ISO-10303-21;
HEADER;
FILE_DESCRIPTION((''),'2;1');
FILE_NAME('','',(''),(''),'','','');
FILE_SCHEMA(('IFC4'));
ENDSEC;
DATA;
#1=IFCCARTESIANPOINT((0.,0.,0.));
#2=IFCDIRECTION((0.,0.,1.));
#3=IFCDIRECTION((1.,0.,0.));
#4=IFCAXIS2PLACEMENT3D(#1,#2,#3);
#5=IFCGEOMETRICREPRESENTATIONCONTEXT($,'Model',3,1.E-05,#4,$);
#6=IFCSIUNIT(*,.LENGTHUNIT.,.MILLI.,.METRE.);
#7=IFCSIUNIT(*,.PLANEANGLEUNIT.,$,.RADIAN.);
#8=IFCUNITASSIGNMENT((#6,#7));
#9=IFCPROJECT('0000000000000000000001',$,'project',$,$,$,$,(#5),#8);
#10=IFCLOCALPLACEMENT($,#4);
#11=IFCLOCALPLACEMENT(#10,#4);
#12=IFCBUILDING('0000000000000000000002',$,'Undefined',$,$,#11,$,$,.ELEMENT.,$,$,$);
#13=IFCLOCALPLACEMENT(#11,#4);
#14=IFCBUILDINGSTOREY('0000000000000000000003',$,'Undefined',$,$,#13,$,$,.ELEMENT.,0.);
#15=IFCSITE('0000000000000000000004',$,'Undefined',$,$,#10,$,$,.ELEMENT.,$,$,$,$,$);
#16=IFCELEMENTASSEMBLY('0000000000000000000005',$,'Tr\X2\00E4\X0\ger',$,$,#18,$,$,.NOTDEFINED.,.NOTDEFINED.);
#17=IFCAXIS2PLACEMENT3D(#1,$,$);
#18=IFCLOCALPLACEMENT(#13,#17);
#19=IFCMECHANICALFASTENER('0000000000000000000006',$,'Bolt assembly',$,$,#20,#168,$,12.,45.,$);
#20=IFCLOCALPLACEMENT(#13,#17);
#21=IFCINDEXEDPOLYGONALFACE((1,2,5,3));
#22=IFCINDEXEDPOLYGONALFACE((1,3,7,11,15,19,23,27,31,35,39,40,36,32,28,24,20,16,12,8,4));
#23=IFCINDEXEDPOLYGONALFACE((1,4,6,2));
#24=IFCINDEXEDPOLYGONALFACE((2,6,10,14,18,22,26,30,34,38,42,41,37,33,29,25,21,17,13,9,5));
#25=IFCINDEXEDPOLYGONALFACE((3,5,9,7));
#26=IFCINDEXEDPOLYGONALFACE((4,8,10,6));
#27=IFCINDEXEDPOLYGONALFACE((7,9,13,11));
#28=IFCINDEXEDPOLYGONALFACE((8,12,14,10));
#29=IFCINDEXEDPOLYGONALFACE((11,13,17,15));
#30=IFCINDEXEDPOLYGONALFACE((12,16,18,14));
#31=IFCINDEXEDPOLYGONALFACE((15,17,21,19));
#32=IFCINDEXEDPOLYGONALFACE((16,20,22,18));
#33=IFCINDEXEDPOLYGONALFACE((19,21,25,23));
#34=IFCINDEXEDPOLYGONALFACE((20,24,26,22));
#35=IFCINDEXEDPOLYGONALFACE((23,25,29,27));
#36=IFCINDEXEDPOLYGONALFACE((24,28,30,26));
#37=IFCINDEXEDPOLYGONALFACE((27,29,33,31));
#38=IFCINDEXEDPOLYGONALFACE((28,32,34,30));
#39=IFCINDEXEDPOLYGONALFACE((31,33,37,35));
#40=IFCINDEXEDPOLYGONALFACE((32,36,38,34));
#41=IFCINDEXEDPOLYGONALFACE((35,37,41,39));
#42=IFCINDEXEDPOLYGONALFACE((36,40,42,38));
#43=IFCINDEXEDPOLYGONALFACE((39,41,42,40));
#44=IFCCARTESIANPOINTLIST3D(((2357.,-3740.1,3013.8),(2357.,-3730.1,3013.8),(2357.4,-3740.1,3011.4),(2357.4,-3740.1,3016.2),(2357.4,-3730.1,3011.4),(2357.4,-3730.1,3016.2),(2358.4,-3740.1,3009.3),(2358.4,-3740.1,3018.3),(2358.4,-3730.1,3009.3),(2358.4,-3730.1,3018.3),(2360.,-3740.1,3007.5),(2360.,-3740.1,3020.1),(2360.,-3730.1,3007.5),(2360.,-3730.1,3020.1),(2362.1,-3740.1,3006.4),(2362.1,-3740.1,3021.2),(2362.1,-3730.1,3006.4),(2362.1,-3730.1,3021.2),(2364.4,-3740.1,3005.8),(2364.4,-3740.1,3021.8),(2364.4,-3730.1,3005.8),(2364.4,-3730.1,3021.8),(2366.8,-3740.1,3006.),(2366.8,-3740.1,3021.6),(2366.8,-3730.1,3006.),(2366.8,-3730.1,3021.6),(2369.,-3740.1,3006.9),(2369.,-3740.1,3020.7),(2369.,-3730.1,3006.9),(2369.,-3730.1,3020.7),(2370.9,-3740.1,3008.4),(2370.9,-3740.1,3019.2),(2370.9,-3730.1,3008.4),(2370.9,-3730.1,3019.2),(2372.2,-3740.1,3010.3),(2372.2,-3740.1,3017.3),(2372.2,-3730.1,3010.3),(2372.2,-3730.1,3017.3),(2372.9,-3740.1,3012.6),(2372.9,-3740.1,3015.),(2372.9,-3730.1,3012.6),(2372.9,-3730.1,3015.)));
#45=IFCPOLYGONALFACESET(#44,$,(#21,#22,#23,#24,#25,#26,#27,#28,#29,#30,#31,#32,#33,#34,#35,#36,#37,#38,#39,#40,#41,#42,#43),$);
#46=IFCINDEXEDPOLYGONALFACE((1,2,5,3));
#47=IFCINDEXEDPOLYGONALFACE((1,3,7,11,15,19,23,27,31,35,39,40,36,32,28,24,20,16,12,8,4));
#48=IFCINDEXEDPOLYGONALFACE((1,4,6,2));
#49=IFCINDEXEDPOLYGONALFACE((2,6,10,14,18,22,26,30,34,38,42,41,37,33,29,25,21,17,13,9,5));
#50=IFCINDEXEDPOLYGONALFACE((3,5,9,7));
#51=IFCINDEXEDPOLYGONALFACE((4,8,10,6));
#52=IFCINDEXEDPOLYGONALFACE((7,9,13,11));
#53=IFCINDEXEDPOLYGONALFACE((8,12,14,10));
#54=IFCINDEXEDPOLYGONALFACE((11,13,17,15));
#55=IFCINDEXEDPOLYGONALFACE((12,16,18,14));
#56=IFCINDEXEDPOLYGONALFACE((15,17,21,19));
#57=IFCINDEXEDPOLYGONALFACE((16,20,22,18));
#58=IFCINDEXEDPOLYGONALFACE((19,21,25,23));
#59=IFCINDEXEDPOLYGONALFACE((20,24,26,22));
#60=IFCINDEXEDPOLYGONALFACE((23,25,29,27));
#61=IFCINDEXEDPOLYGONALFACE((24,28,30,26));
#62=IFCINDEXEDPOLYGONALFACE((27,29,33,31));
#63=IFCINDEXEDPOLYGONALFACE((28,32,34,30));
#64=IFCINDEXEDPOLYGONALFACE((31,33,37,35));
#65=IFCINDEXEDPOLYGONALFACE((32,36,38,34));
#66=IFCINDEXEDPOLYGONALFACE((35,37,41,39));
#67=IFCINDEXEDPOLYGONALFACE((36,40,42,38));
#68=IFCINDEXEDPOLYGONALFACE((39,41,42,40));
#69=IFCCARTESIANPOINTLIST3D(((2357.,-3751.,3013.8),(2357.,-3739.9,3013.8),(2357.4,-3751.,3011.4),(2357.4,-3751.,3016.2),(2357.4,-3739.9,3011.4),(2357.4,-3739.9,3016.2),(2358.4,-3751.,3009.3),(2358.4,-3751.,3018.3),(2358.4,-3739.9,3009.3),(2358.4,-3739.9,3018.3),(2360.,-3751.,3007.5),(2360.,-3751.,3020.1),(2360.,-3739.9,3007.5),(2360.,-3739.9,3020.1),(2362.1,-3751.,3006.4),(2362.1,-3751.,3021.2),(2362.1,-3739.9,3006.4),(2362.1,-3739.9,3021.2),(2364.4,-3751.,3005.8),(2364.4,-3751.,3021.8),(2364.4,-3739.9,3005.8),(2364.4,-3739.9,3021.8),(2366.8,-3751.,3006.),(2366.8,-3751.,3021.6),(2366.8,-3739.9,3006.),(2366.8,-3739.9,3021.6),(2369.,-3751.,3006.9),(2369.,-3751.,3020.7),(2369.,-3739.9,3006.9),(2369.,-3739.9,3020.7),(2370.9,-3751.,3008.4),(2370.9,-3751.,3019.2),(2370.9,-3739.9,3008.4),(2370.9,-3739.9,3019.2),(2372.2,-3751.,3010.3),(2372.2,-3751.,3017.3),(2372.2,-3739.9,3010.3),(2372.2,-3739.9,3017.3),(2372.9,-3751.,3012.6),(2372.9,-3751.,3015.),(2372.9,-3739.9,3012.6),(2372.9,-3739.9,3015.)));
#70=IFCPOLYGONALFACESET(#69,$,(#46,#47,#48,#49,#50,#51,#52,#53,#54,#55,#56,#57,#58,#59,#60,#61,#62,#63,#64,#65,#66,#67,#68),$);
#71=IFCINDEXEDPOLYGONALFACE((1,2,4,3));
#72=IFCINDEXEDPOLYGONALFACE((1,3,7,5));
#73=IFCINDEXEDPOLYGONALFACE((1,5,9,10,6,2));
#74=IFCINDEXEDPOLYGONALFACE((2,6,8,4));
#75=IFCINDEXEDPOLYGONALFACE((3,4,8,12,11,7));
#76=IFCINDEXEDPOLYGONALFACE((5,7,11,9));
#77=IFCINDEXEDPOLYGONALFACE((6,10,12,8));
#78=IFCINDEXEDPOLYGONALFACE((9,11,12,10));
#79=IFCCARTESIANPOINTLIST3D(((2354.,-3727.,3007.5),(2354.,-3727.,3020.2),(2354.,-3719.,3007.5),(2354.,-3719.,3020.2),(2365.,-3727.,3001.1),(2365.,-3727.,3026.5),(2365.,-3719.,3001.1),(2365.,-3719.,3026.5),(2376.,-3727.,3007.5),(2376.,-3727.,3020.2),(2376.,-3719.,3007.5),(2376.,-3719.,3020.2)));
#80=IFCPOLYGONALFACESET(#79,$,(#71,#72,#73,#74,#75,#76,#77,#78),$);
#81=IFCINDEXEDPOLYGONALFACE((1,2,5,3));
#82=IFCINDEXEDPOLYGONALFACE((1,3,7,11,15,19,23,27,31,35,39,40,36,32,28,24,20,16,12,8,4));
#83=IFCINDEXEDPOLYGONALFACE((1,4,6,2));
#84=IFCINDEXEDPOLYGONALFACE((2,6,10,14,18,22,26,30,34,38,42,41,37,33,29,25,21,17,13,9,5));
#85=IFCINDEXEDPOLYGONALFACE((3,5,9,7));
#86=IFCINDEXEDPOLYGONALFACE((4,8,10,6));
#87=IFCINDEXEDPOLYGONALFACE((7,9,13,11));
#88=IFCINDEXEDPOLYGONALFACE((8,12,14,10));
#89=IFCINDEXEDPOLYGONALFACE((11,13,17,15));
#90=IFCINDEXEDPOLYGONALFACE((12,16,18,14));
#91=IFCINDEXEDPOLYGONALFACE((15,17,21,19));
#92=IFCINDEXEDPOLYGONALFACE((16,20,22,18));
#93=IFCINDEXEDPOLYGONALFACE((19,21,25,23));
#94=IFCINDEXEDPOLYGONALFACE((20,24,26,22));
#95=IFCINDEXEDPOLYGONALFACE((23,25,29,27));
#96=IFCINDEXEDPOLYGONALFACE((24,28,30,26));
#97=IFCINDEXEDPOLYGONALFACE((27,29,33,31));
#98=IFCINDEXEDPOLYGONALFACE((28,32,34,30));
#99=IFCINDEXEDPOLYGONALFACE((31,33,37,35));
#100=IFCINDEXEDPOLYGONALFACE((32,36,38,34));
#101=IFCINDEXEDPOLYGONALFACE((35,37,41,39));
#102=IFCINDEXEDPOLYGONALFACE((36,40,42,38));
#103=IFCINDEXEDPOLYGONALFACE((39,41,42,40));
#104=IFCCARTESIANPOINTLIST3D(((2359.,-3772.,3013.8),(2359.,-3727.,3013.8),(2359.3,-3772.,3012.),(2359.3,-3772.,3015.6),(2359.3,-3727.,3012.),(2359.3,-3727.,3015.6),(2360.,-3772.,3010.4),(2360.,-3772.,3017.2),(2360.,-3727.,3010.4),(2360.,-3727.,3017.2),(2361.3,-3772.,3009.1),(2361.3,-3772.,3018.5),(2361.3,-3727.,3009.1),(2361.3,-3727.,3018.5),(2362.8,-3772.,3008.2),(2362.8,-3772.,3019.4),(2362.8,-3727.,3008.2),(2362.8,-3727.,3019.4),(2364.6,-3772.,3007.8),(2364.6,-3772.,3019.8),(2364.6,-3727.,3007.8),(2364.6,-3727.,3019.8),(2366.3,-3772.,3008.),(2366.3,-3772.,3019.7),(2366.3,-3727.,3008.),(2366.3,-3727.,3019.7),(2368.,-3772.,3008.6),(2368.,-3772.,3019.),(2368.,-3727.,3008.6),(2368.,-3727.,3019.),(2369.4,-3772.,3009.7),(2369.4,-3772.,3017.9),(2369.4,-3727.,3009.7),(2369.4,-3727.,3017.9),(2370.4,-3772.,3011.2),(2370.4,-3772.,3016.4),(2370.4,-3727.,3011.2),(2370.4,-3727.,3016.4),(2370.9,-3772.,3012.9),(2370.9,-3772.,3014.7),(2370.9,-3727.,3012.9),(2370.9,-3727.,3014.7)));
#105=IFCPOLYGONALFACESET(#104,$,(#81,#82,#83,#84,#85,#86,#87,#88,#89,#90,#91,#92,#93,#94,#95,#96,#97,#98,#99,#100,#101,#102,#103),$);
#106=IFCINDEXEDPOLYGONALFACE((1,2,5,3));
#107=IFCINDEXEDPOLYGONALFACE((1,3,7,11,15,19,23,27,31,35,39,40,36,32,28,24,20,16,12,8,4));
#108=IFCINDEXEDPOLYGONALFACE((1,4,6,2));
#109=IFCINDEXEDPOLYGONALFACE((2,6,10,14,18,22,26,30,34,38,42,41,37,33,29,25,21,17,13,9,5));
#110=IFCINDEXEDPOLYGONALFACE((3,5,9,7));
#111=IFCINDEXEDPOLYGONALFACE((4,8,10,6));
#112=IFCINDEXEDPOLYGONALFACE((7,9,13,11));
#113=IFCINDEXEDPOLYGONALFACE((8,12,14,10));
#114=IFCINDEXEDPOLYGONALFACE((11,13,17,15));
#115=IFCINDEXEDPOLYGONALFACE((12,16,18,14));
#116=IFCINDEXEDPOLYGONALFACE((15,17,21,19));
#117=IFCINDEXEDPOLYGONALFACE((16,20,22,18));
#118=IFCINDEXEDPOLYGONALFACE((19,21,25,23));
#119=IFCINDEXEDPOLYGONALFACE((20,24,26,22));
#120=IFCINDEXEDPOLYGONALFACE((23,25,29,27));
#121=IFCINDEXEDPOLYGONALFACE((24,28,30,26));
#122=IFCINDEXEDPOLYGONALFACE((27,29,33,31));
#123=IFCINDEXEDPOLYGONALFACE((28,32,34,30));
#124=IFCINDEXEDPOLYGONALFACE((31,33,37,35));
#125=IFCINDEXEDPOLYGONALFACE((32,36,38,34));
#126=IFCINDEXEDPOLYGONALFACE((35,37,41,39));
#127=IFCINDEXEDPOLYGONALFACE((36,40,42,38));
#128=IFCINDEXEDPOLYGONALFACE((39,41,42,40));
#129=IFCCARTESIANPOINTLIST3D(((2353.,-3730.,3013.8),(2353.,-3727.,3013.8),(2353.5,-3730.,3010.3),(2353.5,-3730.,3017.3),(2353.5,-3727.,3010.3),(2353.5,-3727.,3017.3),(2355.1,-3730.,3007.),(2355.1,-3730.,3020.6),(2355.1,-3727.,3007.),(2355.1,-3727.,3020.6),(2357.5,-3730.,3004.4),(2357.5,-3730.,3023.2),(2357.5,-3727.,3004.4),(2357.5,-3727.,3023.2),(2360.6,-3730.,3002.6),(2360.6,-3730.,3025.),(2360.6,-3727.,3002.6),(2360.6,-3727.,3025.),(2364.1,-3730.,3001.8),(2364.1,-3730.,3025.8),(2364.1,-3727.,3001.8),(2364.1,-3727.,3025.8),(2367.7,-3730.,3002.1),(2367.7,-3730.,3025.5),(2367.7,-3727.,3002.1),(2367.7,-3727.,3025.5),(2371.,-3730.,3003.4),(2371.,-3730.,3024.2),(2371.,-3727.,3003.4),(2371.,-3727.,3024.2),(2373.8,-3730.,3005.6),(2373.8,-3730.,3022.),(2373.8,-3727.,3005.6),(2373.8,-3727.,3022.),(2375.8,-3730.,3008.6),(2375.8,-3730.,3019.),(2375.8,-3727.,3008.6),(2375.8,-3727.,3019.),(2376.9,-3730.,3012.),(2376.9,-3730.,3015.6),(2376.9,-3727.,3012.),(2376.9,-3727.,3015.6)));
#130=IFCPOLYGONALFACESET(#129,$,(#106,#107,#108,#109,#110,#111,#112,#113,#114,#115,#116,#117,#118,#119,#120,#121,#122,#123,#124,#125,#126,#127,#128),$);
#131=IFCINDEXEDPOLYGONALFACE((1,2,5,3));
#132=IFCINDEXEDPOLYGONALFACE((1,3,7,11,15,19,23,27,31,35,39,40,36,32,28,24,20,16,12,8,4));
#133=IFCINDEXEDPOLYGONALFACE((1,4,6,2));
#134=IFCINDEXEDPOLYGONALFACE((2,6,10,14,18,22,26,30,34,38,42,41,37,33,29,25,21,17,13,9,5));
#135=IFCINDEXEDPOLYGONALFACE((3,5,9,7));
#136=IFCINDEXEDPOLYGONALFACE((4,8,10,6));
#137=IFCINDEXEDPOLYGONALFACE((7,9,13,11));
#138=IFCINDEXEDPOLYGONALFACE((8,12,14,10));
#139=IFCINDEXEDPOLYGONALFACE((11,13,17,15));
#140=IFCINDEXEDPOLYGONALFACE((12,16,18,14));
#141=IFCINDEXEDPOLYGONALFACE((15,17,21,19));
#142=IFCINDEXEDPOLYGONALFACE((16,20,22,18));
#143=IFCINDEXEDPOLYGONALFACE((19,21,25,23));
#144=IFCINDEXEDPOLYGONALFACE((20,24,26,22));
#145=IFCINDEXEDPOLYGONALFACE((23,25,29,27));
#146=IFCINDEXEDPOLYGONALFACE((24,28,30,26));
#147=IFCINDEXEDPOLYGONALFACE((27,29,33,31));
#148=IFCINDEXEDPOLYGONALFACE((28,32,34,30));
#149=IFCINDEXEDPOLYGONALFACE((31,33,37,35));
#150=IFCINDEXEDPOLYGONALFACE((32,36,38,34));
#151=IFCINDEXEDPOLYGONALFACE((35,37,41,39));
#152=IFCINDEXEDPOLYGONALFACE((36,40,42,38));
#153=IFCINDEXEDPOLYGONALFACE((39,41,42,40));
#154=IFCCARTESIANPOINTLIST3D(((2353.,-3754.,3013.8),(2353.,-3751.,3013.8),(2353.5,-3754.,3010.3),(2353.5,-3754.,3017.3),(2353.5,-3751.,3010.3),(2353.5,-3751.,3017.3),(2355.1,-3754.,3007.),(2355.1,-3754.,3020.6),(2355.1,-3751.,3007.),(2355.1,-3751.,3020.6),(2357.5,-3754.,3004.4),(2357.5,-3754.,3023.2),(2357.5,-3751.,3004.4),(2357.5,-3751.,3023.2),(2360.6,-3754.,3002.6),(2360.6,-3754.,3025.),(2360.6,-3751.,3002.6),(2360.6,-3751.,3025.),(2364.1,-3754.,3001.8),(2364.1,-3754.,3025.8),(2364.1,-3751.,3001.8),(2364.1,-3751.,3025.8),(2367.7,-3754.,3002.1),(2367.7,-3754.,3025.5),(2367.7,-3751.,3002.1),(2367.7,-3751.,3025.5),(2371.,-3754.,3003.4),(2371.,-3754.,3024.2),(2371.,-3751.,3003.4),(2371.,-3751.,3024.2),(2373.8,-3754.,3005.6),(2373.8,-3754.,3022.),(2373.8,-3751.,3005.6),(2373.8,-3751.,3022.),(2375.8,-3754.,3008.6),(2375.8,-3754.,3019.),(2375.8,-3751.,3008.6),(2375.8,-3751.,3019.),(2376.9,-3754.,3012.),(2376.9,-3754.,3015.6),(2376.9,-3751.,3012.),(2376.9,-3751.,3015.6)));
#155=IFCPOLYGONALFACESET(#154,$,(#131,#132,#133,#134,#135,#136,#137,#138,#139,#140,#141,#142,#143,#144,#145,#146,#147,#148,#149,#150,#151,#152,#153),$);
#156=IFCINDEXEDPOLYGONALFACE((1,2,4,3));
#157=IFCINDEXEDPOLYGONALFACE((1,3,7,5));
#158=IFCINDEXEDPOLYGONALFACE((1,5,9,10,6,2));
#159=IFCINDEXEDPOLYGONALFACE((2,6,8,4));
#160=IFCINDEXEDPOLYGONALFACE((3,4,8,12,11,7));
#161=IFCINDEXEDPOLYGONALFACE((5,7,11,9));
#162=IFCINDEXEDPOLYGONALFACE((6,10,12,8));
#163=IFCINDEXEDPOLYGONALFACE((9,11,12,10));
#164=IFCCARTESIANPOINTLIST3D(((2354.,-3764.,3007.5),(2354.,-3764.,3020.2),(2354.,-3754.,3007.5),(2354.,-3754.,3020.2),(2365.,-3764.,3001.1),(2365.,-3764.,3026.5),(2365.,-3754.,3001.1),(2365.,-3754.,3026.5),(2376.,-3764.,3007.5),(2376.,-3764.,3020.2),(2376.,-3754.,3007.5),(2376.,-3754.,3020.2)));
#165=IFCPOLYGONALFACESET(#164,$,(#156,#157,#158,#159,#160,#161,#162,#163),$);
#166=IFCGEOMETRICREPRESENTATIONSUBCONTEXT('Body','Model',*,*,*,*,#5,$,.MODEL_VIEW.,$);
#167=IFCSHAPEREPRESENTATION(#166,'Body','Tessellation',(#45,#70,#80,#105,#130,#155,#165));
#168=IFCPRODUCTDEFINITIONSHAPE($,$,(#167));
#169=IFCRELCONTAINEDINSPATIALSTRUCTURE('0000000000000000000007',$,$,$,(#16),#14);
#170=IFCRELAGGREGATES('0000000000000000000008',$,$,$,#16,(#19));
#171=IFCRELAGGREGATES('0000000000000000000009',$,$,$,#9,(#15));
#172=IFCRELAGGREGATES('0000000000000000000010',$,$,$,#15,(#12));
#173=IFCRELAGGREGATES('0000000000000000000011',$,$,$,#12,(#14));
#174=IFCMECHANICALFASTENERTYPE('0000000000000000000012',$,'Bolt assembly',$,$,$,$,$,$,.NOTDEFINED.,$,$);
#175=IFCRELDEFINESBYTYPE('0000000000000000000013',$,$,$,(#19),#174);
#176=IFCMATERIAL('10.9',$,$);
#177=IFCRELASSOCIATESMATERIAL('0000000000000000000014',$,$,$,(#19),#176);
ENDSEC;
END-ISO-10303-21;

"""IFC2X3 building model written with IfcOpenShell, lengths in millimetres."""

from ifc_helpers import new_model, si_unit, frame, origin_with_axes, origin_2d_with_axis, place, context, subcontext, project, spatial, polyline, circle, outline, extrude, source, transform, mapped, material, type_object, element, aggregate, save


model = new_model("IFC2X3")

# Units and contexts
model_context = context("Model", 3, precision=1e-05, world=origin_with_axes())
body_context = subcontext(model_context, "Body", "Model", "MODEL_VIEW")
ifc_project = project(units=[si_unit("LENGTHUNIT", "METRE", prefix="MILLI"), si_unit("PLANEANGLEUNIT", "RADIAN")], contexts=[model_context])

# Site, building, storey
site_placement = place(None, origin_with_axes())
site = spatial("IfcSite", under=ifc_project, at=site_placement, Name="Undefined", CompositionType="ELEMENT")
building_placement = place(site_placement, origin_with_axes())
building = spatial("IfcBuilding", under=site, at=building_placement, Name="Undefined", CompositionType="ELEMENT")
storey_placement = place(building_placement, origin_with_axes())
storey = spatial("IfcBuildingStorey", under=building, at=storey_placement, Name="Undefined", CompositionType="ELEMENT", Elevation=0.0)

# Element assembly
assembly_1_placement = place(storey_placement, origin_with_axes())
assembly_1 = element("IfcElementAssembly", 1, at=assembly_1_placement, inside=storey, Name="Träger", AssemblyPlace="NOTDEFINED", PredefinedType="NOTDEFINED")

# Mechanical fastener
ifc_material_1 = material(Name="10.9")
mechanical_fastener_type = type_object("IfcMechanicalFastenerType", Name="Bolt assembly")
shared_shape_1 = source(origin_with_axes(), body_context, "Body", "SweptSolid", [
    extrude(circle(Radius=8.0, at=origin_2d_with_axis()), frame((0.0, 0.1, 0.0), z_axis=(0.0, 1.0, 0.0), x_axis=(1.0, 0.0, 0.0)), (0.0, 0.0, 1.0), 10.0),
    extrude(circle(Radius=8.0, at=origin_2d_with_axis()), frame((0.0, 9.9, 0.0), z_axis=(0.0, 1.0, 0.0), x_axis=(1.0, 0.0, 0.0)), (0.0, 0.0, 1.0), 11.1),
    extrude(outline(polyline([(11.0, -6.4), (11.0, 6.4), (0.0, 12.7), (-11.0, 6.4), (-11.0, -6.4), (0.0, -12.7), (11.0, -6.4)])), frame((0.0, -11.0, 0.0), z_axis=(0.0, 1.0, 0.0), x_axis=(1.0, 0.0, 0.0)), (0.0, 0.0, 1.0), 8.0),
    extrude(circle(Radius=6.0, at=origin_2d_with_axis()), frame((0.0, -3.0, 0.0), z_axis=(0.0, 1.0, 0.0), x_axis=(1.0, 0.0, 0.0)), (0.0, 0.0, 1.0), 45.0),
    extrude(circle(Radius=12.0, at=origin_2d_with_axis()), frame((0.0, -3.0, 0.0), z_axis=(0.0, 1.0, 0.0), x_axis=(1.0, 0.0, 0.0)), (0.0, 0.0, 1.0), 3.0),
    extrude(circle(Radius=12.0, at=origin_2d_with_axis()), frame((0.0, 21.0, 0.0), z_axis=(0.0, 1.0, 0.0), x_axis=(1.0, 0.0, 0.0)), (0.0, 0.0, 1.0), 3.0),
    extrude(outline(polyline([(11.0, -6.4), (11.0, 6.4), (0.0, 12.7), (-11.0, 6.4), (-11.0, -6.4), (0.0, -12.7), (11.0, -6.4)])), frame((0.0, 24.0, 0.0), z_axis=(0.0, 1.0, 0.0), x_axis=(1.0, 0.0, 0.0)), (0.0, 0.0, 1.0), 10.0),
])
mechanical_fastener_1_placement = place(assembly_1_placement, frame((2365.0, -3730.0, 3013.8), z_axis=(0.0, 0.0, 1.0), x_axis=(-1.0, 0.0, 0.0)))
mechanical_fastener_1 = element("IfcMechanicalFastener", 2, at=mechanical_fastener_1_placement, type_object=mechanical_fastener_type, material=ifc_material_1, Name="Bolt assembly", NominalDiameter=12.0, NominalLength=45.0, context=body_context, shape_type="MappedRepresentation", body=[
    mapped(shared_shape_1, transform((0.0, 0.0, 0.0))),
])
aggregate(assembly_1, [mechanical_fastener_1])

save(model, "model.ifc")
